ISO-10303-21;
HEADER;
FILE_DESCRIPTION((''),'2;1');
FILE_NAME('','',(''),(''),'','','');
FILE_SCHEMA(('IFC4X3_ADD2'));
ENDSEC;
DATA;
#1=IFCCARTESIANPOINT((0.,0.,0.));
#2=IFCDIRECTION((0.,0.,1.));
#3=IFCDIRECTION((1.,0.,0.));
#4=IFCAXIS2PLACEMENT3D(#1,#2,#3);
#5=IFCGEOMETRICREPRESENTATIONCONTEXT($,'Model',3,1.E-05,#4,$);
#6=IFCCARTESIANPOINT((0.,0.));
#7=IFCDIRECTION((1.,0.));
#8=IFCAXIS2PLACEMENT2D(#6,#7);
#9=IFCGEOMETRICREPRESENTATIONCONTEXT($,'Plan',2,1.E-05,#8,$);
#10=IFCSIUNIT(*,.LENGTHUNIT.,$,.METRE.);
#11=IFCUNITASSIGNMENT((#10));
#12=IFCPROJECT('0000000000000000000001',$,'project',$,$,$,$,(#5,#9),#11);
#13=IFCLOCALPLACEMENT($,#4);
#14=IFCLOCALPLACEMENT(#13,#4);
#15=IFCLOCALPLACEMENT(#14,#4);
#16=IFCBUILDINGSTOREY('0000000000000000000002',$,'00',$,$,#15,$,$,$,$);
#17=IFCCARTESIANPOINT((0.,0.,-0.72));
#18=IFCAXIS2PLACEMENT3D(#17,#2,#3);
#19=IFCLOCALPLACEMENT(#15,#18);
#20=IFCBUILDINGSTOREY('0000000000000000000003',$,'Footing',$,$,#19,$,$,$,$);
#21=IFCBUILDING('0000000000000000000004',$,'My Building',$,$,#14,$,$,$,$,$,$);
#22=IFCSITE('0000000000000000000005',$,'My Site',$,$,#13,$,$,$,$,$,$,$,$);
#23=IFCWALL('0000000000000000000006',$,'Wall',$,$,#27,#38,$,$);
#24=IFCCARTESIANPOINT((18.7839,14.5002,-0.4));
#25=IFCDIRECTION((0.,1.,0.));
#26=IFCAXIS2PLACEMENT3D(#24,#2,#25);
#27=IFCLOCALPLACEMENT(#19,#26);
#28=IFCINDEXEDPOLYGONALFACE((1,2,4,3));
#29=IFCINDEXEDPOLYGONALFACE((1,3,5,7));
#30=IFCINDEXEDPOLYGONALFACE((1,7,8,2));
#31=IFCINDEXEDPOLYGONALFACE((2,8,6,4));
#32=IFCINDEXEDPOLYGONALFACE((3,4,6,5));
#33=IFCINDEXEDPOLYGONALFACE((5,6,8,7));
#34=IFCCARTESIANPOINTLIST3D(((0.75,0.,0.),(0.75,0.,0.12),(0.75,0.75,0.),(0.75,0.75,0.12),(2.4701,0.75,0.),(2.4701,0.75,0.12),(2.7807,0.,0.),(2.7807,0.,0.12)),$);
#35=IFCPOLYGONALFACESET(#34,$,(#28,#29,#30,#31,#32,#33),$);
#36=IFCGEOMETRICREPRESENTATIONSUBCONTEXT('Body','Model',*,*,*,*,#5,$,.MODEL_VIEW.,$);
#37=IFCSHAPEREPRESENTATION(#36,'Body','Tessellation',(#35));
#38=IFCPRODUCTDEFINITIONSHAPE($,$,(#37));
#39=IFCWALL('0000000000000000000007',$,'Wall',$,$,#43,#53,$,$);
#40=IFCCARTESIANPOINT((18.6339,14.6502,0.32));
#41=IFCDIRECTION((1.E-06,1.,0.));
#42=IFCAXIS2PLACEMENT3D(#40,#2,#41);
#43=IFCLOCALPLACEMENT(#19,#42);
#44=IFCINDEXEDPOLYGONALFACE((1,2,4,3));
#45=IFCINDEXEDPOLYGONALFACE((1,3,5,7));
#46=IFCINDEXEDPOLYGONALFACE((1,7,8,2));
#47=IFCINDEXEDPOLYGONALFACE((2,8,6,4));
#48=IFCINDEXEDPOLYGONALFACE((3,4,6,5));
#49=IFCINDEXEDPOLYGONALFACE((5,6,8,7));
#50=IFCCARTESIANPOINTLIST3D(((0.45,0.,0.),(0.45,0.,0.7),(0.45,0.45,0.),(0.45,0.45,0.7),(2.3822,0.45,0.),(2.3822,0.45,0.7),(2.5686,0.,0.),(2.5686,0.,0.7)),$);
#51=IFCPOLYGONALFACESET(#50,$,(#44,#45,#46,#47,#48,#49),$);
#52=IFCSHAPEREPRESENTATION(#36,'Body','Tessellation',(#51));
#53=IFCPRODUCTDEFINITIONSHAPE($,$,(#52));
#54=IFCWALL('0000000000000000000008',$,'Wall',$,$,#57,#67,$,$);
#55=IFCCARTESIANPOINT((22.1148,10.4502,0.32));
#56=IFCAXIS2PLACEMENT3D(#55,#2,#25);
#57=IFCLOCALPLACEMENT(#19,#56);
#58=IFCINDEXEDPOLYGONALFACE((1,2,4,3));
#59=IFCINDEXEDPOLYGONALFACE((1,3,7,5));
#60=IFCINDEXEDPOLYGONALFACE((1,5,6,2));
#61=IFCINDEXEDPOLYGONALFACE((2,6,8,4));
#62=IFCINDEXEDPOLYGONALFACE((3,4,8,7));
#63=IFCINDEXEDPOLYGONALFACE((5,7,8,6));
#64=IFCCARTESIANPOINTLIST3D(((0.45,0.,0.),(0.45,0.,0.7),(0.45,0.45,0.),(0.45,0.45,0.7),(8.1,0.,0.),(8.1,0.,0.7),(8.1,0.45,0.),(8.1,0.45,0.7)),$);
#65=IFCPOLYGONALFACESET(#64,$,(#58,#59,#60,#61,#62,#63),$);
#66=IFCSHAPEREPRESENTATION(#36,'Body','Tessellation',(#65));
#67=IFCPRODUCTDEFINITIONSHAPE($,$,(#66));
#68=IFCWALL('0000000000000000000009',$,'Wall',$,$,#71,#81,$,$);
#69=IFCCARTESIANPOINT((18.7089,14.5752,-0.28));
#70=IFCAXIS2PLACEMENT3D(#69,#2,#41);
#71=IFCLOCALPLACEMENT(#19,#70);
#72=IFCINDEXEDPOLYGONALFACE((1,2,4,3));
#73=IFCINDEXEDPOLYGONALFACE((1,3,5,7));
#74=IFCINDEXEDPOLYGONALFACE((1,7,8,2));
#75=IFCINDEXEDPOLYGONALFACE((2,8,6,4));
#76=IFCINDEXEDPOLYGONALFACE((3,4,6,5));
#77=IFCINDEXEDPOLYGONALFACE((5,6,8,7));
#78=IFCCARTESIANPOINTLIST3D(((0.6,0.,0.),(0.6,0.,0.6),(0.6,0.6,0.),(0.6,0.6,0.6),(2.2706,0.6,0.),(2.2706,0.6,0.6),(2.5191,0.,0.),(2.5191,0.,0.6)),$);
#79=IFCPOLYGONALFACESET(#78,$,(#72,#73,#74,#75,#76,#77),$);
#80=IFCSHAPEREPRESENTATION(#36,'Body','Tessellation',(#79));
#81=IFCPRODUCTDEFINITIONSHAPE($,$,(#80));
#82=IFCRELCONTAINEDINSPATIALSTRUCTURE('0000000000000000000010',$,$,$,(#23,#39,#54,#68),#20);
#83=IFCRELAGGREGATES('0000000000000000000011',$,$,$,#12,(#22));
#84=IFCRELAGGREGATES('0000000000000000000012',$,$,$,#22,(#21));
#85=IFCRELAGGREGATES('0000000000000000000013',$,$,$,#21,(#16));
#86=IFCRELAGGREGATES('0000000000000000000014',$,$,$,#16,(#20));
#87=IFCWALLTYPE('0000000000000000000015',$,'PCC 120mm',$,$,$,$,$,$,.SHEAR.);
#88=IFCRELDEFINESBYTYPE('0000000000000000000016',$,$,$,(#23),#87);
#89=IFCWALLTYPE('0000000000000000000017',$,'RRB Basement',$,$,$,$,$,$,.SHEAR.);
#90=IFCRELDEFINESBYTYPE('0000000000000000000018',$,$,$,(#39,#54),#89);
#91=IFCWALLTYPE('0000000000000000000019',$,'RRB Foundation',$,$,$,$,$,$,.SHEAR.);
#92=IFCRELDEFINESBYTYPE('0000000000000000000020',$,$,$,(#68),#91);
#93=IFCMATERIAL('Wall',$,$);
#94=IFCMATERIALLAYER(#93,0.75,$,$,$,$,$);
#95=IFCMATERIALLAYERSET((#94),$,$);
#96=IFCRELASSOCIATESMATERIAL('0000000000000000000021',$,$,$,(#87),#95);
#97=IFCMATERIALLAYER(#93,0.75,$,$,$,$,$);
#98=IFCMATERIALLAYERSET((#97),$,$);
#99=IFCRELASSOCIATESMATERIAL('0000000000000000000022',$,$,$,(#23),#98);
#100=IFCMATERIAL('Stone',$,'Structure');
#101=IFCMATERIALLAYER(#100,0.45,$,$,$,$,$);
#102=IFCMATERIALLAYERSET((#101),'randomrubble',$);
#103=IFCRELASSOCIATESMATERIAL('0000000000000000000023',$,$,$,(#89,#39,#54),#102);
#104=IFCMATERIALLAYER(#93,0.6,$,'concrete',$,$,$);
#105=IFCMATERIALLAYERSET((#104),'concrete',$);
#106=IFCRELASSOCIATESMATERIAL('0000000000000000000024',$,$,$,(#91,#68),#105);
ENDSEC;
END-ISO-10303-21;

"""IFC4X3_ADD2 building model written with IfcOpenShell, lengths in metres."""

from ifc_helpers import new_model, si_unit, frame, origin_with_axes, origin_2d_with_axis, place, context, subcontext, project, spatial, line, indexed_curve, outline, extrude, material, layer, layer_set, layer_usage, type_object, element, save


model = new_model("IFC4X3_ADD2")

# Units and contexts
model_context = context("Model", 3, precision=1e-05, world=origin_with_axes())
plan_context = context("Plan", 2, precision=1e-05, world=origin_2d_with_axis())
body_context = subcontext(model_context, "Body", "Model", "MODEL_VIEW")
ifc_project = project(units=[si_unit("LENGTHUNIT", "METRE")], contexts=[model_context, plan_context])

# Site, building, storeys
site_placement = place(None, origin_with_axes())
site = spatial("IfcSite", under=ifc_project, at=site_placement, Name="My Site")
building_placement = place(site_placement, origin_with_axes())
building = spatial("IfcBuilding", under=site, at=building_placement, Name="My Building")
storey_1_placement = place(building_placement, origin_with_axes())
storey_1 = spatial("IfcBuildingStorey", under=building, at=storey_1_placement, Name="00")
storey_2_placement = place(storey_1_placement, frame((0.0, 0.0, -0.72), z_axis=(0.0, 0.0, 1.0), x_axis=(1.0, 0.0, 0.0)))
storey_2 = spatial("IfcBuildingStorey", under=storey_1, at=storey_2_placement, Name="Footing")

# Shared definitions
ifc_material_1 = material(Name="Stone", Category="Structure")

# Walls
ifc_material_2 = material(Name="Wall")
ifc_layer_1 = layer(ifc_material_2, 0.75)
ifc_layer_set_1 = layer_set([ifc_layer_1])
wall_type_1 = type_object("IfcWallType", Name="PCC 120mm", PredefinedType="SHEAR", material=ifc_layer_set_1)
ifc_layer_2 = layer(ifc_material_2, 0.75)
ifc_layer_set_2 = layer_set([ifc_layer_2])
ifc_layer_usage_1 = layer_usage(ifc_layer_set_2, "AXIS2", "POSITIVE", 0.0)
wall_1_placement = place(storey_2_placement, frame((18.7839, 14.5002, -0.4), z_axis=(0.0, 0.0, 1.0), x_axis=(0.0, 1.0, 0.0)))
element("IfcWall", 1, at=wall_1_placement, inside=storey_2, type_object=wall_type_1, material=ifc_layer_usage_1, Name="Wall", context=body_context, shape_type="SweptSolid", body=[
    extrude(outline(indexed_curve([(0.75, 0.0), (0.75, 0.75), (2.4701, 0.75), (2.7807, 0.0)], segments=[line(1, 2, 3, 4, 1)])), origin_with_axes(), (0.0, 0.0, 1.0), 0.12),
])
ifc_layer_3 = layer(ifc_material_1, 0.45)
ifc_layer_set_3 = layer_set([ifc_layer_3], Name="randomrubble")
wall_type_2 = type_object("IfcWallType", Name="RRB Basement", PredefinedType="SHEAR", material=ifc_layer_set_3)
ifc_layer_usage_2 = layer_usage(ifc_layer_set_3, "AXIS2", "POSITIVE", 0.0)
wall_2_placement = place(storey_2_placement, frame((18.6339, 14.6502, 0.32), z_axis=(0.0, 0.0, 1.0), x_axis=(0.000001, 1.0, 0.0)))
element("IfcWall", 2, at=wall_2_placement, inside=storey_2, type_object=wall_type_2, material=ifc_layer_usage_2, Name="Wall", context=body_context, shape_type="SweptSolid", body=[
    extrude(outline(indexed_curve([(0.45, 0.0), (0.45, 0.45), (2.3822, 0.45), (2.5686, 0.0)], segments=[line(1, 2, 3, 4, 1)])), origin_with_axes(), (0.0, 0.0, 1.0), 0.7),
])
ifc_layer_usage_3 = layer_usage(ifc_layer_set_3, "AXIS2", "POSITIVE", 0.0)
wall_3_placement = place(storey_2_placement, frame((22.1148, 10.4502, 0.32), z_axis=(0.0, 0.0, 1.0), x_axis=(0.0, 1.0, 0.0)))
element("IfcWall", 3, at=wall_3_placement, inside=storey_2, type_object=wall_type_2, material=ifc_layer_usage_3, Name="Wall", context=body_context, shape_type="SweptSolid", body=[
    extrude(outline(indexed_curve([(0.45, 0.0), (0.45, 0.45), (8.1, 0.45), (8.1, 0.0)], segments=[line(1, 2, 3, 4, 1)])), origin_with_axes(), (0.0, 0.0, 1.0), 0.7),
])
ifc_layer_4 = layer(ifc_material_2, 0.6, Name="concrete")
ifc_layer_set_4 = layer_set([ifc_layer_4], Name="concrete")
wall_type_3 = type_object("IfcWallType", Name="RRB Foundation", PredefinedType="SHEAR", material=ifc_layer_set_4)
ifc_layer_usage_4 = layer_usage(ifc_layer_set_4, "AXIS2", "POSITIVE", 0.0)
wall_4_placement = place(storey_2_placement, frame((18.7089, 14.5752, -0.28), z_axis=(0.0, 0.0, 1.0), x_axis=(0.000001, 1.0, 0.0)))
element("IfcWall", 4, at=wall_4_placement, inside=storey_2, type_object=wall_type_3, material=ifc_layer_usage_4, Name="Wall", context=body_context, shape_type="SweptSolid", body=[
    extrude(outline(indexed_curve([(0.6, 0.0), (0.6, 0.6), (2.2706, 0.6), (2.5191, 0.0)], segments=[line(1, 2, 3, 4, 1)])), origin_with_axes(), (0.0, 0.0, 1.0), 0.6),
])

save(model, "model.ifc")
